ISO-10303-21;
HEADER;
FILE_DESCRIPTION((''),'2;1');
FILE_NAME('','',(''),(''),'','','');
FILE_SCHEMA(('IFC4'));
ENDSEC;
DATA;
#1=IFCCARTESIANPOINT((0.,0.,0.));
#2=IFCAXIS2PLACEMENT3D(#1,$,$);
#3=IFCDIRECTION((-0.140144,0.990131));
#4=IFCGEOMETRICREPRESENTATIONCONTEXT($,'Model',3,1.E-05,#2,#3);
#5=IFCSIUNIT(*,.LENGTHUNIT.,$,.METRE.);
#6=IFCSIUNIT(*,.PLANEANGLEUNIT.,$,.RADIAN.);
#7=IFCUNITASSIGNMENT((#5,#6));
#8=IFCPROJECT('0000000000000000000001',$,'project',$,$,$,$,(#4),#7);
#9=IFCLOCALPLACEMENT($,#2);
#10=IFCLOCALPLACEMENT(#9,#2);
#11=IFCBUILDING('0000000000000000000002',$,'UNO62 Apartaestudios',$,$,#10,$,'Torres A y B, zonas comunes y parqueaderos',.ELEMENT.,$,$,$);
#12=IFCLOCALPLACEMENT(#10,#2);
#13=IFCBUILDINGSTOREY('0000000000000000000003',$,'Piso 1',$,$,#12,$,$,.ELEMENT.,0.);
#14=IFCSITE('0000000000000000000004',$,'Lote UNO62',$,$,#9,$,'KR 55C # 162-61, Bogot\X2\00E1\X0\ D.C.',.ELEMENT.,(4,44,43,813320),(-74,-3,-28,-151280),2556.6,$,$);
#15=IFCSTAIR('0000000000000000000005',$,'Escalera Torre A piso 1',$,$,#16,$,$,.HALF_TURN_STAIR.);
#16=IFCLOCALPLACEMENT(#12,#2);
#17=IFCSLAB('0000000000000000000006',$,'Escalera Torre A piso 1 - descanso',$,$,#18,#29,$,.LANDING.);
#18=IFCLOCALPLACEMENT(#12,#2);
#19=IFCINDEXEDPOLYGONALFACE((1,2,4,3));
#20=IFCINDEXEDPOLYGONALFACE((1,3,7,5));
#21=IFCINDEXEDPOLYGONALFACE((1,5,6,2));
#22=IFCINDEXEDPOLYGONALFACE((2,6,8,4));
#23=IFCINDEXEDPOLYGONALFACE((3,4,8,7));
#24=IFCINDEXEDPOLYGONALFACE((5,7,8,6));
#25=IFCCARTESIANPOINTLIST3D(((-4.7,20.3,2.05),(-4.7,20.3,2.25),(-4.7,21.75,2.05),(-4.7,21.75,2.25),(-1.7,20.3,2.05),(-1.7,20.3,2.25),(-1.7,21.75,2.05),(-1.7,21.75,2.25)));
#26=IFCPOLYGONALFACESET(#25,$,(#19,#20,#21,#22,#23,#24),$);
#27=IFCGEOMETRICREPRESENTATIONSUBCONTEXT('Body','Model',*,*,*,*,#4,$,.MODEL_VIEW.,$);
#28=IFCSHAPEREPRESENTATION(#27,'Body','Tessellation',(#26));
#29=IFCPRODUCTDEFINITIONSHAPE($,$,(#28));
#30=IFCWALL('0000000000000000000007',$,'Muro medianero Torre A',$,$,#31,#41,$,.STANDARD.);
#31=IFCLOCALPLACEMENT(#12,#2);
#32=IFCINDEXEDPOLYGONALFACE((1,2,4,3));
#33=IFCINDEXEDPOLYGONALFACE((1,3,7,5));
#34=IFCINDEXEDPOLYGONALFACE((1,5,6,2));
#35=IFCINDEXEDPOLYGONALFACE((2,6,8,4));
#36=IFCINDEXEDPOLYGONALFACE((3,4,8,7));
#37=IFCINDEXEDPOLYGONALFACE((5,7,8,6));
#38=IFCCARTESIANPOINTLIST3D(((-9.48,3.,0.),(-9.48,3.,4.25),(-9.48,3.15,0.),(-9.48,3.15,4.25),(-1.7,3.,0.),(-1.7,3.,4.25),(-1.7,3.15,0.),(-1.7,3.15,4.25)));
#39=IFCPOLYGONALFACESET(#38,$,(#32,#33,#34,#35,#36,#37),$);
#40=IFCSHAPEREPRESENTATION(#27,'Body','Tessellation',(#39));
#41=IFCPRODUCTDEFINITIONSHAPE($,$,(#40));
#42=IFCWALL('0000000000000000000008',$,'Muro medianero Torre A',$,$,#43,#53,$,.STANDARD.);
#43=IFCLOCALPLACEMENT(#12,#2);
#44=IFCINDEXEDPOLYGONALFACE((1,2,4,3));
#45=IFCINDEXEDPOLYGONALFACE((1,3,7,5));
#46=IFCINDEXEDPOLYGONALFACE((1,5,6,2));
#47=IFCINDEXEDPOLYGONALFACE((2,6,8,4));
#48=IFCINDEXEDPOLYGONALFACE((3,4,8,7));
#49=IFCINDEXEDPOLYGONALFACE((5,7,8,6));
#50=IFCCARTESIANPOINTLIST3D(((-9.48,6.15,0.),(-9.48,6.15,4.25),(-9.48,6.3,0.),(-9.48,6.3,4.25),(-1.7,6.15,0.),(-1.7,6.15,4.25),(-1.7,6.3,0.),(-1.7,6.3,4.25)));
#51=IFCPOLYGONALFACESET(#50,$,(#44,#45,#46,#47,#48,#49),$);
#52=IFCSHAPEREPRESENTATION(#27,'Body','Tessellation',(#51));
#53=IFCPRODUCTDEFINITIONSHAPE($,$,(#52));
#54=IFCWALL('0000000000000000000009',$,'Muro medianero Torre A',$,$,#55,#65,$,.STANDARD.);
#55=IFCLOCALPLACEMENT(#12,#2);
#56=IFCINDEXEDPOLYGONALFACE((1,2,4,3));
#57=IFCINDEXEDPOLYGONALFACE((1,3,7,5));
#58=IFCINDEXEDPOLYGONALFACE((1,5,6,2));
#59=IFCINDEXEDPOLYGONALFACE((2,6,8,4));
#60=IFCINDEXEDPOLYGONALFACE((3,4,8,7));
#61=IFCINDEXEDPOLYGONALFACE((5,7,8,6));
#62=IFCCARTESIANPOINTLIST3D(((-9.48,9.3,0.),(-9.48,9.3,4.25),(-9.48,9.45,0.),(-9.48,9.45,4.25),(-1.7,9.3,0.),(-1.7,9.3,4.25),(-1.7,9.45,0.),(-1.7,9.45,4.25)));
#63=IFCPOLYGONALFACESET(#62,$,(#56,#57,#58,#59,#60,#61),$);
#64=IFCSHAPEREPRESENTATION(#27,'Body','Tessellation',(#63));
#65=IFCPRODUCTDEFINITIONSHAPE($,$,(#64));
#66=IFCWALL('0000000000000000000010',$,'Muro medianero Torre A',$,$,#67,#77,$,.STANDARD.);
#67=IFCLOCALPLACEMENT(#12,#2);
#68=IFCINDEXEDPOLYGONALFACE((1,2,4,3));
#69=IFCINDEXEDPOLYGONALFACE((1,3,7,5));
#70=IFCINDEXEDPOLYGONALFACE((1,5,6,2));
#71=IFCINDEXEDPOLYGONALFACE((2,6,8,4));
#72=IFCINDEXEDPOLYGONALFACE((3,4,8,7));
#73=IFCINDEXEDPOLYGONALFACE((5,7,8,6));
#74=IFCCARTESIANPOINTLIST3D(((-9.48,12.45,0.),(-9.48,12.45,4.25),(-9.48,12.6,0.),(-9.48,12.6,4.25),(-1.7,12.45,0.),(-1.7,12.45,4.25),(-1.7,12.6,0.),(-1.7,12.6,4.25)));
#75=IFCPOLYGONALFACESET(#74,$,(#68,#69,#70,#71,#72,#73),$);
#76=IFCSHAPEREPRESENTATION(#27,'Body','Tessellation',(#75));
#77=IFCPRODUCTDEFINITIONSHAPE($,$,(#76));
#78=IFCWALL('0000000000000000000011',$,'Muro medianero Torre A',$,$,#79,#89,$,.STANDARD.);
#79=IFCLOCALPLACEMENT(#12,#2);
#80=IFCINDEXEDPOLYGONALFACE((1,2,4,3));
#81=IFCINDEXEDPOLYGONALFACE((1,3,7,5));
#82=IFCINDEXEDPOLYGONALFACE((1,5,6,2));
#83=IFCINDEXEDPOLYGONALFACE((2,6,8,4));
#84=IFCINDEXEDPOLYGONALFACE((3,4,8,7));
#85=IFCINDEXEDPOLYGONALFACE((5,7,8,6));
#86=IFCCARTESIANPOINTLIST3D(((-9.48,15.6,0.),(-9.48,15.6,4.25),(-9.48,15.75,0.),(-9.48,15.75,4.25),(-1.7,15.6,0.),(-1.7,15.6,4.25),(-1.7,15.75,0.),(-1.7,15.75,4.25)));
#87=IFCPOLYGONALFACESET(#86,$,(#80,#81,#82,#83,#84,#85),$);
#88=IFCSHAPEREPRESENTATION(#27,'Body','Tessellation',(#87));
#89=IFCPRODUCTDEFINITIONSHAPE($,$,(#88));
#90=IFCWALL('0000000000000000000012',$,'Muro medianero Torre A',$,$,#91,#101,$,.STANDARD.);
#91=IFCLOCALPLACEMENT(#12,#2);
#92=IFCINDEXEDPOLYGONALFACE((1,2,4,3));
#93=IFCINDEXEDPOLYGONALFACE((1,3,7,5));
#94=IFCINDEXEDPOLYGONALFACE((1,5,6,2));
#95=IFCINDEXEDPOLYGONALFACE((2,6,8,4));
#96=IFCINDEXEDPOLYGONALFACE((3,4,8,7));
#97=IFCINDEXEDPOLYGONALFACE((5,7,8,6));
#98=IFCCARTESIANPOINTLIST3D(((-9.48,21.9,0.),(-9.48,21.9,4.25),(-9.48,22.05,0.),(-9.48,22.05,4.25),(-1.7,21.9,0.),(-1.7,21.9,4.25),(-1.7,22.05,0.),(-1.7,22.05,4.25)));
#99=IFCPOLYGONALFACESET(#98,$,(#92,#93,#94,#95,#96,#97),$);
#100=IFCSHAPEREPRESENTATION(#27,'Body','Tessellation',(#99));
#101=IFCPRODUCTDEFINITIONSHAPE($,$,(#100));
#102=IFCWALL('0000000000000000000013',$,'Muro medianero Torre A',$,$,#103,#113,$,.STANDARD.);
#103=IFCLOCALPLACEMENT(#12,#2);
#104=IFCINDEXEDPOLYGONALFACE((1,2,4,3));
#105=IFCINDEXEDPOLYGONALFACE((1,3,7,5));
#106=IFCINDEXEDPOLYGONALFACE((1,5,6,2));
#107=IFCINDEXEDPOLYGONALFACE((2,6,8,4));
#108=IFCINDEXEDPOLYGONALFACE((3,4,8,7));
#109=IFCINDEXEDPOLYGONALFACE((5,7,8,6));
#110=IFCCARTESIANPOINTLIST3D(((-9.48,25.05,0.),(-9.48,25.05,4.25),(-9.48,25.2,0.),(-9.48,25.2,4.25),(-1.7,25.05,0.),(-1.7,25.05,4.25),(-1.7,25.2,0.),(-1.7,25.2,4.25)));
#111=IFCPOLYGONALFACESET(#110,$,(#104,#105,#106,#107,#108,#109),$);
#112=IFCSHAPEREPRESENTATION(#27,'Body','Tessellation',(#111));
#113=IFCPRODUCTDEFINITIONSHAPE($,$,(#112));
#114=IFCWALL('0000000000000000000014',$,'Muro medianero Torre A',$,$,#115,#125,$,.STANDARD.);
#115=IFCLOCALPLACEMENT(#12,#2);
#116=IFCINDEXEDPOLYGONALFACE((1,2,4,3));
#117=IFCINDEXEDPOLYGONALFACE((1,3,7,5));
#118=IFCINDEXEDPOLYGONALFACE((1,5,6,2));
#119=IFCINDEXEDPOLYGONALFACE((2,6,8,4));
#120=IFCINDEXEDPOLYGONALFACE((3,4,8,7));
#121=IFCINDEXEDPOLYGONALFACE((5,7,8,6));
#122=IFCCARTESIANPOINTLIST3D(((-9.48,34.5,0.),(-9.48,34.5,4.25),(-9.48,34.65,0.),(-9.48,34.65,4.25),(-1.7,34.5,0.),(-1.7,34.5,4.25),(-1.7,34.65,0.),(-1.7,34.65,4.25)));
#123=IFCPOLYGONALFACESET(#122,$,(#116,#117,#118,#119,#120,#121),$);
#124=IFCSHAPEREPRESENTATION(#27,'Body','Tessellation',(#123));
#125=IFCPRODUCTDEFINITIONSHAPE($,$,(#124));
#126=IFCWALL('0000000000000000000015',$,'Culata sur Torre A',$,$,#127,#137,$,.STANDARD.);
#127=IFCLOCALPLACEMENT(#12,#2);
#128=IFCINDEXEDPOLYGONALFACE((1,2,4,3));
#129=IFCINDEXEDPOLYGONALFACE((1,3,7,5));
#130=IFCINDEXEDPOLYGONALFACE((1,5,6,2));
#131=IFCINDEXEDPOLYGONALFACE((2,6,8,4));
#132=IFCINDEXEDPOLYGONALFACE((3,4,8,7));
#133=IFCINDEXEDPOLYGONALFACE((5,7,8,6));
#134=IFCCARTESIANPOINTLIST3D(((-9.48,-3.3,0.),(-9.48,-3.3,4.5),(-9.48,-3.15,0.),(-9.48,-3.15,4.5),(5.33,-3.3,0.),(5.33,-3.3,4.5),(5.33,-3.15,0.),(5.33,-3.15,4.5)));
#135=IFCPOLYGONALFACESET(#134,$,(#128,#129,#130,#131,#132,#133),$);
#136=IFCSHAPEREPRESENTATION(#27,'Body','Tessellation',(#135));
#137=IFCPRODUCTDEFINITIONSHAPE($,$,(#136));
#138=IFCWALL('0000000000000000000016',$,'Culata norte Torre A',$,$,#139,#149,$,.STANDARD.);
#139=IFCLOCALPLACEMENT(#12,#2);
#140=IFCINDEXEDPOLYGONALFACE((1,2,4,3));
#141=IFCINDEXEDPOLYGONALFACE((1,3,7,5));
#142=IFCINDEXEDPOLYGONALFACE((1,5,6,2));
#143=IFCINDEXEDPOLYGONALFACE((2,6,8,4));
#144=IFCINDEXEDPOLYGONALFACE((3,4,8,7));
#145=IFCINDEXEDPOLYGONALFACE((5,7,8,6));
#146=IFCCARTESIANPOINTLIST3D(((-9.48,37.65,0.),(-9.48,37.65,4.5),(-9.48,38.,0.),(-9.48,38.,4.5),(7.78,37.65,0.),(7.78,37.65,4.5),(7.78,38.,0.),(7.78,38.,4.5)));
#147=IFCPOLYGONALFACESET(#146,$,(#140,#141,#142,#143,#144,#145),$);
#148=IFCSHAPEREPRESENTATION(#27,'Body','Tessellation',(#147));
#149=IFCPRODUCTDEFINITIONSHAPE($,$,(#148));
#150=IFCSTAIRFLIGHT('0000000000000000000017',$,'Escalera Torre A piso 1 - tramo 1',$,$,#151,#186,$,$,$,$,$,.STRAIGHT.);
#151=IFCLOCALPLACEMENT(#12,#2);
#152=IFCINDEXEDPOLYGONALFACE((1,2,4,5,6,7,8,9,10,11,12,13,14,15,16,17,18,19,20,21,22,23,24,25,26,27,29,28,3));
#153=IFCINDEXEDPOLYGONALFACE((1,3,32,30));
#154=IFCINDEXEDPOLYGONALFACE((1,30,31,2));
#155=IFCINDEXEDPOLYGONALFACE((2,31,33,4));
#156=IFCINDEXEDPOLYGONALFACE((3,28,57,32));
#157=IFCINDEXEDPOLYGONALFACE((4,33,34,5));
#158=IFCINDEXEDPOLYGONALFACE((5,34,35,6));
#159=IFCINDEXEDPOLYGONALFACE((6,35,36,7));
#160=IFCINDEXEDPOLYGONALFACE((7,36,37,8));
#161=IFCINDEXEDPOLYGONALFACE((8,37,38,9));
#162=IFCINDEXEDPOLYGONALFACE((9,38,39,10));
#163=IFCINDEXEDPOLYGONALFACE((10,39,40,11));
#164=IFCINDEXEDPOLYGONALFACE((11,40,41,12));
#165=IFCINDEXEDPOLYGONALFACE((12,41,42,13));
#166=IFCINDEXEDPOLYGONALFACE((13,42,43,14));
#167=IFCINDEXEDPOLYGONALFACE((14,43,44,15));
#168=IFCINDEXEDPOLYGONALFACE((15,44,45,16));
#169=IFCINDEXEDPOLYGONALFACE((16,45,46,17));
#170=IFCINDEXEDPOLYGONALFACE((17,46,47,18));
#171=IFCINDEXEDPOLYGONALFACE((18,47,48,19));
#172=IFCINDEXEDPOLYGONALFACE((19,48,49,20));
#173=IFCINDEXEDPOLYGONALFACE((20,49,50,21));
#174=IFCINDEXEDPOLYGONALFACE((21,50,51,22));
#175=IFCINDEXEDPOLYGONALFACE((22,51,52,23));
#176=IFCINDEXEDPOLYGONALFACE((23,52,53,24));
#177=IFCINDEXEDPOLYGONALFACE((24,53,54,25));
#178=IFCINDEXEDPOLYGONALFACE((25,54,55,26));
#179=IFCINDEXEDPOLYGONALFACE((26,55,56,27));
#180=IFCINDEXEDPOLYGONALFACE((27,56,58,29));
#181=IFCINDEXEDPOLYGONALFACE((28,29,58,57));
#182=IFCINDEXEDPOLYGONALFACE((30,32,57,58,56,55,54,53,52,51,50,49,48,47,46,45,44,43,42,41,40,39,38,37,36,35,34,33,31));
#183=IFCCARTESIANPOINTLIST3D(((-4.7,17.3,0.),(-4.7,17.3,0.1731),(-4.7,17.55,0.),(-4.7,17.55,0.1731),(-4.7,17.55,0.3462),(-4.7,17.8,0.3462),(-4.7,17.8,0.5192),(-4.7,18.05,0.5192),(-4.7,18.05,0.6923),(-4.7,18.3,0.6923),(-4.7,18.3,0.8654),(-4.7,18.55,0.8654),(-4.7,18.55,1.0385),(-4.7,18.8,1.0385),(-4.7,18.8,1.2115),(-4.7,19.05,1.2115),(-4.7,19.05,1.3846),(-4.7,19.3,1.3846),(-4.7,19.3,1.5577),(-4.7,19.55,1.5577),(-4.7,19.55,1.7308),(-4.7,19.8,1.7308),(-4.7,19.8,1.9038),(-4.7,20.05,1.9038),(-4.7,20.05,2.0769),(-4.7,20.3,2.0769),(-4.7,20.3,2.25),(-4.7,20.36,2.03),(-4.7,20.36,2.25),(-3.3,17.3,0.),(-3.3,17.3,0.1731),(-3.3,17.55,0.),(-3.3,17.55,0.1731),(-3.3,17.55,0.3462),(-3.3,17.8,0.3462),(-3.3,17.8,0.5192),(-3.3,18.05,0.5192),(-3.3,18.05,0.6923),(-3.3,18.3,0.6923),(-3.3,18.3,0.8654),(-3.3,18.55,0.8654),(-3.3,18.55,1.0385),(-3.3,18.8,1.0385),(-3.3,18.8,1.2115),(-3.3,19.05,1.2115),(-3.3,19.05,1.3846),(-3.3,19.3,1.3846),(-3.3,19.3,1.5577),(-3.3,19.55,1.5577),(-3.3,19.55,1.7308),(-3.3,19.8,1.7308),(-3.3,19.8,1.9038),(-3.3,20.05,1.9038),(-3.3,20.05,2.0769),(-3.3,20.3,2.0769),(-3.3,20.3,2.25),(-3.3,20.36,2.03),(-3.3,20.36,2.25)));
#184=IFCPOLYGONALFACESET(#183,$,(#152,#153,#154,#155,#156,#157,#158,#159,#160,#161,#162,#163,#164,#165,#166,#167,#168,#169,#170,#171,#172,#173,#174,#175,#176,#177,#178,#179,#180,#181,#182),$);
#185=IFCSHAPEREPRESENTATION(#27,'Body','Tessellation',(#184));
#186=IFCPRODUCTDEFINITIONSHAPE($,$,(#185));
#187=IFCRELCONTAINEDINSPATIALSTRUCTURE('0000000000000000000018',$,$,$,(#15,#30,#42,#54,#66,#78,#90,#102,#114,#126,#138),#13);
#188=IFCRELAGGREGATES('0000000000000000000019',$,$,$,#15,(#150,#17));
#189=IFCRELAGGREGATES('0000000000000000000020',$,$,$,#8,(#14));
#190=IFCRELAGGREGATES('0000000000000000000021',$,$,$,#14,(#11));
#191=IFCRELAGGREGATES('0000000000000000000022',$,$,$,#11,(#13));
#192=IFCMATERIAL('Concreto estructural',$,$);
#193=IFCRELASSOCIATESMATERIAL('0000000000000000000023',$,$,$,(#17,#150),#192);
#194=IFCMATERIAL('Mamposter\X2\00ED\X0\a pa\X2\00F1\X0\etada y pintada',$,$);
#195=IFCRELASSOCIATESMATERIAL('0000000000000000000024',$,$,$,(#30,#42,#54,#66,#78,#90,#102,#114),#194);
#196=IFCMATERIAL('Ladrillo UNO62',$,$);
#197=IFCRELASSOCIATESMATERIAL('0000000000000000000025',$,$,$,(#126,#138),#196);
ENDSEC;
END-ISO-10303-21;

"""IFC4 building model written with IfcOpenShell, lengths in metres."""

from ifc_helpers import new_model, si_unit, direction, frame, frame_2d, origin, place, context, subcontext, project, spatial, polyline, rectangle, outline, extrude, material, element, aggregate, save


model = new_model("IFC4")

# Units and contexts
model_context = context("Model", 3, precision=1e-05, world=origin(), true_north=direction((-0.140144, 0.990131)))
body_context = subcontext(model_context, "Body", "Model", "MODEL_VIEW")
ifc_project = project(units=[si_unit("LENGTHUNIT", "METRE"), si_unit("PLANEANGLEUNIT", "RADIAN")], contexts=[model_context])

# Site, building, storey
site_placement = place(None, origin())
site = spatial("IfcSite", under=ifc_project, at=site_placement, Name="Lote UNO62", LongName="KR 55C # 162-61, Bogotá D.C.", CompositionType="ELEMENT", RefLatitude=(4, 44, 43, 813320), RefLongitude=(-74, -3, -28, -151280), RefElevation=2556.6)
building_placement = place(site_placement, origin())
building = spatial("IfcBuilding", under=site, at=building_placement, Name="UNO62 Apartaestudios", LongName="Torres A y B, zonas comunes y parqueaderos", CompositionType="ELEMENT")
storey_placement = place(building_placement, origin())
storey = spatial("IfcBuildingStorey", under=building, at=storey_placement, Name="Piso 1", CompositionType="ELEMENT", Elevation=0.0)

# Stair, slab
stair_placement = place(storey_placement, origin())
stair = element("IfcStair", 1, at=stair_placement, inside=storey, Name="Escalera Torre A piso 1", PredefinedType="HALF_TURN_STAIR")
ifc_material_1 = material(Name="Concreto estructural")
slab_placement = place(storey_placement, origin())
slab = element("IfcSlab", 2, at=slab_placement, material=ifc_material_1, Name="Escalera Torre A piso 1 - descanso", PredefinedType="LANDING", context=body_context, shape_type="SweptSolid", body=[
    extrude(rectangle(XDim=3.0, YDim=1.45, at=frame_2d((-3.2, 21.025))), frame((0.0, 0.0, 2.05)), (0.0, 0.0, 1.0), 0.2),
])

# Walls
ifc_material_2 = material(Name="Mampostería pañetada y pintada")
wall_1_placement = place(storey_placement, origin())
element("IfcWall", 3, at=wall_1_placement, inside=storey, material=ifc_material_2, Name="Muro medianero Torre A", PredefinedType="STANDARD", context=body_context, shape_type="SweptSolid", body=[
    extrude(rectangle(XDim=7.78, YDim=0.15, at=frame_2d((-5.59, 3.075))), origin(), (0.0, 0.0, 1.0), 4.25),
])
wall_2_placement = place(storey_placement, origin())
element("IfcWall", 4, at=wall_2_placement, inside=storey, material=ifc_material_2, Name="Muro medianero Torre A", PredefinedType="STANDARD", context=body_context, shape_type="SweptSolid", body=[
    extrude(rectangle(XDim=7.78, YDim=0.15, at=frame_2d((-5.59, 6.225))), origin(), (0.0, 0.0, 1.0), 4.25),
])
wall_3_placement = place(storey_placement, origin())
element("IfcWall", 5, at=wall_3_placement, inside=storey, material=ifc_material_2, Name="Muro medianero Torre A", PredefinedType="STANDARD", context=body_context, shape_type="SweptSolid", body=[
    extrude(rectangle(XDim=7.78, YDim=0.15, at=frame_2d((-5.59, 9.375))), origin(), (0.0, 0.0, 1.0), 4.25),
])
wall_4_placement = place(storey_placement, origin())
element("IfcWall", 6, at=wall_4_placement, inside=storey, material=ifc_material_2, Name="Muro medianero Torre A", PredefinedType="STANDARD", context=body_context, shape_type="SweptSolid", body=[
    extrude(rectangle(XDim=7.78, YDim=0.15, at=frame_2d((-5.59, 12.525))), origin(), (0.0, 0.0, 1.0), 4.25),
])
wall_5_placement = place(storey_placement, origin())
element("IfcWall", 7, at=wall_5_placement, inside=storey, material=ifc_material_2, Name="Muro medianero Torre A", PredefinedType="STANDARD", context=body_context, shape_type="SweptSolid", body=[
    extrude(rectangle(XDim=7.78, YDim=0.15, at=frame_2d((-5.59, 15.675))), origin(), (0.0, 0.0, 1.0), 4.25),
])
wall_6_placement = place(storey_placement, origin())
element("IfcWall", 8, at=wall_6_placement, inside=storey, material=ifc_material_2, Name="Muro medianero Torre A", PredefinedType="STANDARD", context=body_context, shape_type="SweptSolid", body=[
    extrude(rectangle(XDim=7.78, YDim=0.15, at=frame_2d((-5.59, 21.975))), origin(), (0.0, 0.0, 1.0), 4.25),
])
wall_7_placement = place(storey_placement, origin())
element("IfcWall", 9, at=wall_7_placement, inside=storey, material=ifc_material_2, Name="Muro medianero Torre A", PredefinedType="STANDARD", context=body_context, shape_type="SweptSolid", body=[
    extrude(rectangle(XDim=7.78, YDim=0.15, at=frame_2d((-5.59, 25.125))), origin(), (0.0, 0.0, 1.0), 4.25),
])
wall_8_placement = place(storey_placement, origin())
element("IfcWall", 10, at=wall_8_placement, inside=storey, material=ifc_material_2, Name="Muro medianero Torre A", PredefinedType="STANDARD", context=body_context, shape_type="SweptSolid", body=[
    extrude(rectangle(XDim=7.78, YDim=0.15, at=frame_2d((-5.59, 34.575))), origin(), (0.0, 0.0, 1.0), 4.25),
])
ifc_material_3 = material(Name="Ladrillo UNO62")
wall_9_placement = place(storey_placement, origin())
element("IfcWall", 11, at=wall_9_placement, inside=storey, material=ifc_material_3, Name="Culata sur Torre A", PredefinedType="STANDARD", context=body_context, shape_type="SweptSolid", body=[
    extrude(rectangle(XDim=14.81, YDim=0.15, at=frame_2d((-2.075, -3.225))), origin(), (0.0, 0.0, 1.0), 4.5),
])
wall_10_placement = place(storey_placement, origin())
element("IfcWall", 12, at=wall_10_placement, inside=storey, material=ifc_material_3, Name="Culata norte Torre A", PredefinedType="STANDARD", context=body_context, shape_type="SweptSolid", body=[
    extrude(rectangle(XDim=17.26, YDim=0.35, at=frame_2d((-0.85, 37.825))), origin(), (0.0, 0.0, 1.0), 4.5),
])

# Stair flight
stair_flight_1_placement = place(storey_placement, origin())
stair_flight_1 = element("IfcStairFlight", 13, at=stair_flight_1_placement, material=ifc_material_1, Name="Escalera Torre A piso 1 - tramo 1", PredefinedType="STRAIGHT", context=body_context, shape_type="SweptSolid", body=[
    extrude(outline(polyline([(0.0, 0.0), (0.0, 0.1731), (0.25, 0.1731), (0.25, 0.3462), (0.5, 0.3462), (0.5, 0.5192), (0.75, 0.5192), (0.75, 0.6923), (1.0, 0.6923), (1.0, 0.8654), (1.25, 0.8654), (1.25, 1.0385), (1.5, 1.0385), (1.5, 1.2115), (1.75, 1.2115), (1.75, 1.3846), (2.0, 1.3846), (2.0, 1.5577), (2.25, 1.5577), (2.25, 1.7308), (2.5, 1.7308), (2.5, 1.9038), (2.75, 1.9038), (2.75, 2.0769), (3.0, 2.0769), (3.0, 2.25), (3.06, 2.25), (3.06, 2.03), (0.25, 0.0), (0.0, 0.0)])), frame((-4.7, 17.3, 0.0), z_axis=(1.0, 0.0, 0.0), x_axis=(0.0, 1.0, 0.0)), (0.0, 0.0, 1.0), 1.4),
])
aggregate(stair, [stair_flight_1, slab])

save(model, "model.ifc")
